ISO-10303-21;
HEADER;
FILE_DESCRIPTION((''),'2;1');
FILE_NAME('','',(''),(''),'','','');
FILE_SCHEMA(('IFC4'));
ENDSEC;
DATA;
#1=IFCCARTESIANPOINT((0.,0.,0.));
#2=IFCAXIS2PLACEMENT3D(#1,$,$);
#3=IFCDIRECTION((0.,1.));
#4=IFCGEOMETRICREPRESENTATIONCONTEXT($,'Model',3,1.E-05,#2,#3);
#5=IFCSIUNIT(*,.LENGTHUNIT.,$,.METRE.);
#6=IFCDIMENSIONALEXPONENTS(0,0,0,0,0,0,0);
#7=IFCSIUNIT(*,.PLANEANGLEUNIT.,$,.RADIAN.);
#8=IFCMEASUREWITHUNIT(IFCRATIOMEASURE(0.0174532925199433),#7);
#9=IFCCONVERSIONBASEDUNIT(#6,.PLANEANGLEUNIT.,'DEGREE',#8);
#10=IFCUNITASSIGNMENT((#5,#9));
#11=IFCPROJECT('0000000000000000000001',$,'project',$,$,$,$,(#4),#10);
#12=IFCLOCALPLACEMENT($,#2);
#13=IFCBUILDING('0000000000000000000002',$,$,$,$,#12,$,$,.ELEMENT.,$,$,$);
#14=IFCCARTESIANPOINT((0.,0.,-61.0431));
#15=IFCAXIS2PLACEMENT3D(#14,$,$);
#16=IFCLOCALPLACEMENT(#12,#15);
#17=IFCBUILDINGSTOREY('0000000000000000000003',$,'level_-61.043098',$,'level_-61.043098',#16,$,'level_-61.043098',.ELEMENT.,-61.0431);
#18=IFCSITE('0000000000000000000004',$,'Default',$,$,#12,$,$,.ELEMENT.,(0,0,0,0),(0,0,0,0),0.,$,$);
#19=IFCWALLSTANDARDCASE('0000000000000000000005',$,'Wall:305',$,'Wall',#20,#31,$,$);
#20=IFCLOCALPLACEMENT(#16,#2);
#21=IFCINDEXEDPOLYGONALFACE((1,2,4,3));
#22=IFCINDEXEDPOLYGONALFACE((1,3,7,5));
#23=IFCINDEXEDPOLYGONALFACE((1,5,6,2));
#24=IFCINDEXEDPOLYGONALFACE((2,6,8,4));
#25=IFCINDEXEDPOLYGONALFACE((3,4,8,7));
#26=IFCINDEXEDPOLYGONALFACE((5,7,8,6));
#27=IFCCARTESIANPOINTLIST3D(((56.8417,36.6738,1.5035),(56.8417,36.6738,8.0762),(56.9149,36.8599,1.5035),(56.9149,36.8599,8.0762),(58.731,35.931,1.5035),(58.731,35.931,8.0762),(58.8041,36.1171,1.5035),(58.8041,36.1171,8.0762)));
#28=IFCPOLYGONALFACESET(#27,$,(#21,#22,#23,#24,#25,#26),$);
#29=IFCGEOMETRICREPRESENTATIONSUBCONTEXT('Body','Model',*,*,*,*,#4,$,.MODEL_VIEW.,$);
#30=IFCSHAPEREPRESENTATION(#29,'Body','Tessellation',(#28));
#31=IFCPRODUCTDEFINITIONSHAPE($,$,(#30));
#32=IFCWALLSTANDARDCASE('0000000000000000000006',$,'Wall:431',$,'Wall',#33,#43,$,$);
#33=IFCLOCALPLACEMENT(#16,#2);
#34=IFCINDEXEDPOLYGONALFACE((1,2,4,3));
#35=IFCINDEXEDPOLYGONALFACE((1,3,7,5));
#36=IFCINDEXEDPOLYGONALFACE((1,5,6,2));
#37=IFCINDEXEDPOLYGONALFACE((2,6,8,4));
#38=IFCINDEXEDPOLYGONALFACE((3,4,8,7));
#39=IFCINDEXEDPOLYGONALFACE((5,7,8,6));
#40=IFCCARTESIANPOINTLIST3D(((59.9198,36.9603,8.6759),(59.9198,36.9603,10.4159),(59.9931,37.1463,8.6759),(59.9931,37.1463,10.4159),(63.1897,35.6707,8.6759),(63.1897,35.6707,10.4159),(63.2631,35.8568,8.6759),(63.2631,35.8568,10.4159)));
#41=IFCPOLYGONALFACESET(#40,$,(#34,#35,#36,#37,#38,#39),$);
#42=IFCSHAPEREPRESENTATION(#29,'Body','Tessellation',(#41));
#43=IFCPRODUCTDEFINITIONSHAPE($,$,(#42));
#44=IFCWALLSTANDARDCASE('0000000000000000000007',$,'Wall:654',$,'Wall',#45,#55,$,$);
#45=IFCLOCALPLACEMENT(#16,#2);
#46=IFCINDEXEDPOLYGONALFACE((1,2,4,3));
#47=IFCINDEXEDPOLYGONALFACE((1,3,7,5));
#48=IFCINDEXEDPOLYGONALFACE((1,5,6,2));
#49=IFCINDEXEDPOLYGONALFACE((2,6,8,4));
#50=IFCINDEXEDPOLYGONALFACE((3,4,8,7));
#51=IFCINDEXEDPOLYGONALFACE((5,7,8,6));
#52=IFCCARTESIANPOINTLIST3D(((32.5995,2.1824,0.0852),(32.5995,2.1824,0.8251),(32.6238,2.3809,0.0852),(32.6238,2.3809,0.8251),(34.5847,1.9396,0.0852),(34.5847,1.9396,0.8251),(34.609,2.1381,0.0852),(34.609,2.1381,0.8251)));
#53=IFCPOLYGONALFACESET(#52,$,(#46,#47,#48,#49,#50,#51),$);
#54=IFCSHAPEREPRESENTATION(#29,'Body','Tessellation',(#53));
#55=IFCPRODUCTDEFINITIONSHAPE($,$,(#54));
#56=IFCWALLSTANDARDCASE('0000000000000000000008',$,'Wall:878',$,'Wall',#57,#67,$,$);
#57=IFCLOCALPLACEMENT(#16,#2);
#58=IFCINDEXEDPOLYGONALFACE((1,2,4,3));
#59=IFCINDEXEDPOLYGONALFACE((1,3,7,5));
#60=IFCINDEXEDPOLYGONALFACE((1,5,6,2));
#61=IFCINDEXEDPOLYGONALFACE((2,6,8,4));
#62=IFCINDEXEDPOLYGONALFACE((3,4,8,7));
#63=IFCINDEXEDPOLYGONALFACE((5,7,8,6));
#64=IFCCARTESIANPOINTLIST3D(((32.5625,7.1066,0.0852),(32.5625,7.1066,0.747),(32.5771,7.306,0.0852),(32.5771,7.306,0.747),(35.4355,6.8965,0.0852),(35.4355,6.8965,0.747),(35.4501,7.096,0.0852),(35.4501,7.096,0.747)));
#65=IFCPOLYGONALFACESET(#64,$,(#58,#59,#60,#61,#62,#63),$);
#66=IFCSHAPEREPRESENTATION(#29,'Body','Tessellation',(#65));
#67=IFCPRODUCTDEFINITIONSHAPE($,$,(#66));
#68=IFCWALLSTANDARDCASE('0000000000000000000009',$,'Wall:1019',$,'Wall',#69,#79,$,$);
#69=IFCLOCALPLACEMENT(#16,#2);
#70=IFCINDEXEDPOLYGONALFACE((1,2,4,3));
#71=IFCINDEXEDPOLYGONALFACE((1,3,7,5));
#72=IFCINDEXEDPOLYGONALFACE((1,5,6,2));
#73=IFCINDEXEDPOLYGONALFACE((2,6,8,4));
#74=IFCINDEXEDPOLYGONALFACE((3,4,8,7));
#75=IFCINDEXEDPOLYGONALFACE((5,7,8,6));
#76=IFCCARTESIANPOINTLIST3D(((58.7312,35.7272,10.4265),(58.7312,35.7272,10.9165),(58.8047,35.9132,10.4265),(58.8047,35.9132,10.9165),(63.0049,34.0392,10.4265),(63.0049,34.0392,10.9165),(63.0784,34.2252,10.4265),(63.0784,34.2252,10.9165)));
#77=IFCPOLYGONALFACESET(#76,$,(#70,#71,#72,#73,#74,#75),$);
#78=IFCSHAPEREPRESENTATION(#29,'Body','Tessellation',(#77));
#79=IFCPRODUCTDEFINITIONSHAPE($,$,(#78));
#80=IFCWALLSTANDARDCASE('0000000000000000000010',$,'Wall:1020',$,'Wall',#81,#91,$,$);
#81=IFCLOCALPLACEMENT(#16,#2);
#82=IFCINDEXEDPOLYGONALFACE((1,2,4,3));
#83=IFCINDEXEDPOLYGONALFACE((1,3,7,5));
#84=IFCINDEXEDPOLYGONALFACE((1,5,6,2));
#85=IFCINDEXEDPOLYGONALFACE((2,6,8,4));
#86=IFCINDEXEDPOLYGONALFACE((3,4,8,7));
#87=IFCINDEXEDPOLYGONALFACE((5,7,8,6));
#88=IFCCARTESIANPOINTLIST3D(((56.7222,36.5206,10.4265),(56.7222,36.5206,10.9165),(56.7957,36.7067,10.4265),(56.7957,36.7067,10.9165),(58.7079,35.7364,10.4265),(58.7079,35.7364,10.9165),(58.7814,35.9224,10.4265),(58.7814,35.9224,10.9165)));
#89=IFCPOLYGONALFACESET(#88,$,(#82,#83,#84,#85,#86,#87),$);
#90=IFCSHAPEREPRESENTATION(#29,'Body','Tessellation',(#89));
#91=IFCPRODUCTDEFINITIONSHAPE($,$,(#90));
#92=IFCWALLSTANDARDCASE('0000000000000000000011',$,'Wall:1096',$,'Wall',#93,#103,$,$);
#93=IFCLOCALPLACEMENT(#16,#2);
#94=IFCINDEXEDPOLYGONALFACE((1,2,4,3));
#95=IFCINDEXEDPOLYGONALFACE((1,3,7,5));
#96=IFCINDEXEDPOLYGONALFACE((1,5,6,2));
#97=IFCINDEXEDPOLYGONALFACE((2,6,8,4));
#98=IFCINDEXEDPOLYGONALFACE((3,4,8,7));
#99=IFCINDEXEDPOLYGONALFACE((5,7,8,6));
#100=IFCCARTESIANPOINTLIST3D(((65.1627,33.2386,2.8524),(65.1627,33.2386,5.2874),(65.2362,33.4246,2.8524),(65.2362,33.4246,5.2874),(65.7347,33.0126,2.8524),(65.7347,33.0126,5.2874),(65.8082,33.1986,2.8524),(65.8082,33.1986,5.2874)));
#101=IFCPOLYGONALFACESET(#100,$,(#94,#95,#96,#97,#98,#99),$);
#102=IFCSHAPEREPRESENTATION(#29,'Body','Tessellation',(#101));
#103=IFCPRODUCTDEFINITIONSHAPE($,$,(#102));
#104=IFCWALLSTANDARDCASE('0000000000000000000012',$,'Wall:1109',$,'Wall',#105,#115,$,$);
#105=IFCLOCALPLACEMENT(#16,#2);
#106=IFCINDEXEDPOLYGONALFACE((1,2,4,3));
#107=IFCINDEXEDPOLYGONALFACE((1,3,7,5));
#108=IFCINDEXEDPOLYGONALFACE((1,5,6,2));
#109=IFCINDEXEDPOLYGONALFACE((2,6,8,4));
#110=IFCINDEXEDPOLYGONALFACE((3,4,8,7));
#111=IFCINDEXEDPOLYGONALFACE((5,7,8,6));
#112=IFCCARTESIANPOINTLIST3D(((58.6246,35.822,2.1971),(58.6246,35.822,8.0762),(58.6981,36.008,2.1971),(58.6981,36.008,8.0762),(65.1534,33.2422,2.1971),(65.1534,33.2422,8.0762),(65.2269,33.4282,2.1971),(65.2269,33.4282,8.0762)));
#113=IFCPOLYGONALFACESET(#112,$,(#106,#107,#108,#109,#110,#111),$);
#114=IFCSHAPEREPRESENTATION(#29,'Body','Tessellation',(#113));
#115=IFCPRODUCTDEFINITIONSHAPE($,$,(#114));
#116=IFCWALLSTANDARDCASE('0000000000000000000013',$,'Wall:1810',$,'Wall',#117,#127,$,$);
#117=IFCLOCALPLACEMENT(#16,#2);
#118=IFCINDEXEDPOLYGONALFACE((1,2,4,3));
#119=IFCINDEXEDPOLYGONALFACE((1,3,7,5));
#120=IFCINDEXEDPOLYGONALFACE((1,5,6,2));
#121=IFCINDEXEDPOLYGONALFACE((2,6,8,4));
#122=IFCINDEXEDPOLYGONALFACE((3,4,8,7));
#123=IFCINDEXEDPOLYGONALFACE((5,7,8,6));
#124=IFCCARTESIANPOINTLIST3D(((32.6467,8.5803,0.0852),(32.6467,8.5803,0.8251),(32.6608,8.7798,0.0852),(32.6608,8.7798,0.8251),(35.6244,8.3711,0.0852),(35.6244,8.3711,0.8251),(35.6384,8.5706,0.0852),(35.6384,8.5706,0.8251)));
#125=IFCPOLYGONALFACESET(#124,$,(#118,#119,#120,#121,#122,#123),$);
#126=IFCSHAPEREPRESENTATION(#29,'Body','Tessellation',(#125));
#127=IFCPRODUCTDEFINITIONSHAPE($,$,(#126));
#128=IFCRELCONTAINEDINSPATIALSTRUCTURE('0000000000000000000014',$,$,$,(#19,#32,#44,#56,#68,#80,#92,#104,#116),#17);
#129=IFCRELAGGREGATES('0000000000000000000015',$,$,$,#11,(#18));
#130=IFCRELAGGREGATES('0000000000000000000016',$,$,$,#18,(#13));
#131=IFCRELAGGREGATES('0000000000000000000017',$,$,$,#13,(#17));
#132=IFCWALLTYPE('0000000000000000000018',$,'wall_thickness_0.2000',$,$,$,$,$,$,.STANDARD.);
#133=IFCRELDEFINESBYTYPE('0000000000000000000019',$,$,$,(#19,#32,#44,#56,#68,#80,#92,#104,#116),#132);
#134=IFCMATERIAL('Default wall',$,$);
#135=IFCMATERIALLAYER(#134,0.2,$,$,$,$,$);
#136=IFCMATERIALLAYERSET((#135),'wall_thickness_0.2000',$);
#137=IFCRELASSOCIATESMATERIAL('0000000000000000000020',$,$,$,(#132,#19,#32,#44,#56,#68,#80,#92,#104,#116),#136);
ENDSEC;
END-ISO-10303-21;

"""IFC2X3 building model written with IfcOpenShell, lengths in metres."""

from ifc_helpers import new_model, entity, si_unit, converted_unit, direction, frame, origin, place, context, subcontext, project, spatial, polyline, outline, extrude, material, layer, layer_set, layer_usage, type_object, element, save


model = new_model("IFC2X3")

# Units and contexts
model_context = context("Model", 3, precision=1e-05, world=origin(), true_north=direction((0.0, 1.0)))
body_context = subcontext(model_context, "Body", "Model", "MODEL_VIEW")
ifc_project = project(units=[si_unit("LENGTHUNIT", "METRE"), converted_unit("PLANEANGLEUNIT", "DEGREE", entity("IfcRatioMeasure", 0.0174532925199433), si_unit("PLANEANGLEUNIT", "RADIAN"), dimensions=[0, 0, 0, 0, 0, 0, 0])], contexts=[model_context])

# Site, building, storey
placement_1 = place(None, origin())
site = spatial("IfcSite", under=ifc_project, at=placement_1, Name="Default", CompositionType="ELEMENT", RefLatitude=(0, 0, 0, 0), RefLongitude=(0, 0, 0, 0), RefElevation=0.0)
building = spatial("IfcBuilding", under=site, at=placement_1, CompositionType="ELEMENT")
storey_placement = place(placement_1, frame((0.0, 0.0, -61.0431)))
storey = spatial("IfcBuildingStorey", under=building, at=storey_placement, Name="level_-61.043098", ObjectType="level_-61.043098", LongName="level_-61.043098", CompositionType="ELEMENT", Elevation=-61.0431)

# Walls
ifc_material = material(Name="Default wall")
ifc_layer = layer(ifc_material, 0.2)
ifc_layer_set = layer_set([ifc_layer], Name="wall_thickness_0.2000")
ifc_layer_usage = layer_usage(ifc_layer_set, "AXIS2", "POSITIVE", -0.1)
wall_type = type_object("IfcWallType", Name="wall_thickness_0.2000", PredefinedType="STANDARD", material=ifc_layer_set)
placement_2 = place(placement_1, frame((0.0, 0.0, -59.5396)))
wall_1_placement = place(placement_2, frame((56.8783, 36.7668, 0.0), z_axis=(0.0, 0.0, 1.0), x_axis=(0.930652, -0.365907, 0.0)))
element("IfcWallStandardCase", 1, at=wall_1_placement, inside=storey, type_object=wall_type, material=ifc_layer_usage, Name="Wall:305", ObjectType="Wall", context=body_context, shape_type="SweptSolid", body=[
    extrude(outline(polyline([(2.03, -0.1), (2.03, 0.1), (0.0, 0.1), (0.0, -0.1), (2.03, -0.1)])), origin(), (0.0, 0.0, 1.0), 6.5727),
])
placement_3 = place(placement_1, frame((0.0, 0.0, -52.3672)))
wall_2_placement = place(placement_3, frame((59.9565, 37.0533, 0.0), z_axis=(0.0, 0.0, 1.0), x_axis=(0.930276, -0.366861, 0.0)))
element("IfcWallStandardCase", 2, at=wall_2_placement, inside=storey, type_object=wall_type, material=ifc_layer_usage, Name="Wall:431", ObjectType="Wall", context=body_context, shape_type="SweptSolid", body=[
    extrude(outline(polyline([(3.515, -0.1), (3.515, 0.1), (0.0, 0.1), (0.0, -0.1), (3.515, -0.1)])), origin(), (0.0, 0.0, 1.0), 1.74),
])
placement_4 = place(placement_1, frame((0.0, 0.0, -60.9579)))
wall_3_placement = place(placement_4, frame((32.6116, 2.2817, 0.0), z_axis=(0.0, 0.0, 1.0), x_axis=(0.992601, -0.121423, 0.0)))
element("IfcWallStandardCase", 3, at=wall_3_placement, inside=storey, type_object=wall_type, material=ifc_layer_usage, Name="Wall:654", ObjectType="Wall", context=body_context, shape_type="SweptSolid", body=[
    extrude(outline(polyline([(2.0, -0.1), (2.0, 0.1), (0.0, 0.1), (0.0, -0.1), (2.0, -0.1)])), origin(), (0.0, 0.0, 1.0), 0.7399),
])
placement_5 = place(placement_1, frame((0.0, 0.0, -60.9579)))
wall_4_placement = place(placement_5, frame((32.5698, 7.2063, 0.0), z_axis=(0.0, 0.0, 1.0), x_axis=(0.997338, -0.072914, 0.0)))
element("IfcWallStandardCase", 4, at=wall_4_placement, inside=storey, type_object=wall_type, material=ifc_layer_usage, Name="Wall:878", ObjectType="Wall", context=body_context, shape_type="SweptSolid", body=[
    extrude(outline(polyline([(2.8807, -0.1), (2.8807, 0.1), (0.0, 0.1), (0.0, -0.1), (2.8807, -0.1)])), origin(), (0.0, 0.0, 1.0), 0.6618),
])
placement_6 = place(placement_1, frame((0.0, 0.0, -50.6166)))
wall_5_placement = place(placement_6, frame((58.7679, 35.8202, 0.0), z_axis=(0.0, 0.0, 1.0), x_axis=(0.930084, -0.367346, 0.0)))
element("IfcWallStandardCase", 5, at=wall_5_placement, inside=storey, type_object=wall_type, material=ifc_layer_usage, Name="Wall:1019", ObjectType="Wall", context=body_context, shape_type="SweptSolid", body=[
    extrude(outline(polyline([(4.595, -0.1), (4.595, 0.1), (0.0, 0.1), (0.0, -0.1), (4.595, -0.1)])), origin(), (0.0, 0.0, 1.0), 0.49),
])
placement_7 = place(placement_1, frame((0.0, 0.0, -50.6166)))
wall_6_placement = place(placement_7, frame((56.7589, 36.6136, 0.0), z_axis=(0.0, 0.0, 1.0), x_axis=(0.930084, -0.367346, 0.0)))
element("IfcWallStandardCase", 6, at=wall_6_placement, inside=storey, type_object=wall_type, material=ifc_layer_usage, Name="Wall:1020", ObjectType="Wall", context=body_context, shape_type="SweptSolid", body=[
    extrude(outline(polyline([(2.135, -0.1), (2.135, 0.1), (0.0, 0.1), (0.0, -0.1), (2.135, -0.1)])), origin(), (0.0, 0.0, 1.0), 0.49),
])
placement_8 = place(placement_1, frame((0.0, 0.0, -58.1907)))
wall_7_placement = place(placement_8, frame((65.1994, 33.3316, 0.0), z_axis=(0.0, 0.0, 1.0), x_axis=(0.93003, -0.367483, 0.0)))
element("IfcWallStandardCase", 7, at=wall_7_placement, inside=storey, type_object=wall_type, material=ifc_layer_usage, Name="Wall:1096", ObjectType="Wall", context=body_context, shape_type="SweptSolid", body=[
    extrude(outline(polyline([(0.615, -0.1), (0.615, 0.1), (0.0, 0.1), (0.0, -0.1), (0.615, -0.1)])), origin(), (0.0, 0.0, 1.0), 2.435),
])
placement_9 = place(placement_1, frame((0.0, 0.0, -58.846)))
wall_8_placement = place(placement_9, frame((58.6613, 35.915, 0.0), z_axis=(0.0, 0.0, 1.0), x_axis=(0.930031, -0.367481, 0.0)))
element("IfcWallStandardCase", 8, at=wall_8_placement, inside=storey, type_object=wall_type, material=ifc_layer_usage, Name="Wall:1109", ObjectType="Wall", context=body_context, shape_type="SweptSolid", body=[
    extrude(outline(polyline([(7.02, -0.1), (7.02, 0.1), (0.0, 0.1), (0.0, -0.1), (7.02, -0.1)])), origin(), (0.0, 0.0, 1.0), 5.8792),
])
placement_10 = place(placement_1, frame((0.0, 0.0, -60.9579)))
wall_9_placement = place(placement_10, frame((32.6538, 8.68, 0.0), z_axis=(0.0, 0.0, 1.0), x_axis=(0.997541, -0.070091, 0.0)))
element("IfcWallStandardCase", 9, at=wall_9_placement, inside=storey, type_object=wall_type, material=ifc_layer_usage, Name="Wall:1810", ObjectType="Wall", context=body_context, shape_type="SweptSolid", body=[
    extrude(outline(polyline([(2.985, -0.1), (2.985, 0.1), (0.0, 0.1), (0.0, -0.1), (2.985, -0.1)])), origin(), (0.0, 0.0, 1.0), 0.7399),
])

save(model, "model.ifc")
